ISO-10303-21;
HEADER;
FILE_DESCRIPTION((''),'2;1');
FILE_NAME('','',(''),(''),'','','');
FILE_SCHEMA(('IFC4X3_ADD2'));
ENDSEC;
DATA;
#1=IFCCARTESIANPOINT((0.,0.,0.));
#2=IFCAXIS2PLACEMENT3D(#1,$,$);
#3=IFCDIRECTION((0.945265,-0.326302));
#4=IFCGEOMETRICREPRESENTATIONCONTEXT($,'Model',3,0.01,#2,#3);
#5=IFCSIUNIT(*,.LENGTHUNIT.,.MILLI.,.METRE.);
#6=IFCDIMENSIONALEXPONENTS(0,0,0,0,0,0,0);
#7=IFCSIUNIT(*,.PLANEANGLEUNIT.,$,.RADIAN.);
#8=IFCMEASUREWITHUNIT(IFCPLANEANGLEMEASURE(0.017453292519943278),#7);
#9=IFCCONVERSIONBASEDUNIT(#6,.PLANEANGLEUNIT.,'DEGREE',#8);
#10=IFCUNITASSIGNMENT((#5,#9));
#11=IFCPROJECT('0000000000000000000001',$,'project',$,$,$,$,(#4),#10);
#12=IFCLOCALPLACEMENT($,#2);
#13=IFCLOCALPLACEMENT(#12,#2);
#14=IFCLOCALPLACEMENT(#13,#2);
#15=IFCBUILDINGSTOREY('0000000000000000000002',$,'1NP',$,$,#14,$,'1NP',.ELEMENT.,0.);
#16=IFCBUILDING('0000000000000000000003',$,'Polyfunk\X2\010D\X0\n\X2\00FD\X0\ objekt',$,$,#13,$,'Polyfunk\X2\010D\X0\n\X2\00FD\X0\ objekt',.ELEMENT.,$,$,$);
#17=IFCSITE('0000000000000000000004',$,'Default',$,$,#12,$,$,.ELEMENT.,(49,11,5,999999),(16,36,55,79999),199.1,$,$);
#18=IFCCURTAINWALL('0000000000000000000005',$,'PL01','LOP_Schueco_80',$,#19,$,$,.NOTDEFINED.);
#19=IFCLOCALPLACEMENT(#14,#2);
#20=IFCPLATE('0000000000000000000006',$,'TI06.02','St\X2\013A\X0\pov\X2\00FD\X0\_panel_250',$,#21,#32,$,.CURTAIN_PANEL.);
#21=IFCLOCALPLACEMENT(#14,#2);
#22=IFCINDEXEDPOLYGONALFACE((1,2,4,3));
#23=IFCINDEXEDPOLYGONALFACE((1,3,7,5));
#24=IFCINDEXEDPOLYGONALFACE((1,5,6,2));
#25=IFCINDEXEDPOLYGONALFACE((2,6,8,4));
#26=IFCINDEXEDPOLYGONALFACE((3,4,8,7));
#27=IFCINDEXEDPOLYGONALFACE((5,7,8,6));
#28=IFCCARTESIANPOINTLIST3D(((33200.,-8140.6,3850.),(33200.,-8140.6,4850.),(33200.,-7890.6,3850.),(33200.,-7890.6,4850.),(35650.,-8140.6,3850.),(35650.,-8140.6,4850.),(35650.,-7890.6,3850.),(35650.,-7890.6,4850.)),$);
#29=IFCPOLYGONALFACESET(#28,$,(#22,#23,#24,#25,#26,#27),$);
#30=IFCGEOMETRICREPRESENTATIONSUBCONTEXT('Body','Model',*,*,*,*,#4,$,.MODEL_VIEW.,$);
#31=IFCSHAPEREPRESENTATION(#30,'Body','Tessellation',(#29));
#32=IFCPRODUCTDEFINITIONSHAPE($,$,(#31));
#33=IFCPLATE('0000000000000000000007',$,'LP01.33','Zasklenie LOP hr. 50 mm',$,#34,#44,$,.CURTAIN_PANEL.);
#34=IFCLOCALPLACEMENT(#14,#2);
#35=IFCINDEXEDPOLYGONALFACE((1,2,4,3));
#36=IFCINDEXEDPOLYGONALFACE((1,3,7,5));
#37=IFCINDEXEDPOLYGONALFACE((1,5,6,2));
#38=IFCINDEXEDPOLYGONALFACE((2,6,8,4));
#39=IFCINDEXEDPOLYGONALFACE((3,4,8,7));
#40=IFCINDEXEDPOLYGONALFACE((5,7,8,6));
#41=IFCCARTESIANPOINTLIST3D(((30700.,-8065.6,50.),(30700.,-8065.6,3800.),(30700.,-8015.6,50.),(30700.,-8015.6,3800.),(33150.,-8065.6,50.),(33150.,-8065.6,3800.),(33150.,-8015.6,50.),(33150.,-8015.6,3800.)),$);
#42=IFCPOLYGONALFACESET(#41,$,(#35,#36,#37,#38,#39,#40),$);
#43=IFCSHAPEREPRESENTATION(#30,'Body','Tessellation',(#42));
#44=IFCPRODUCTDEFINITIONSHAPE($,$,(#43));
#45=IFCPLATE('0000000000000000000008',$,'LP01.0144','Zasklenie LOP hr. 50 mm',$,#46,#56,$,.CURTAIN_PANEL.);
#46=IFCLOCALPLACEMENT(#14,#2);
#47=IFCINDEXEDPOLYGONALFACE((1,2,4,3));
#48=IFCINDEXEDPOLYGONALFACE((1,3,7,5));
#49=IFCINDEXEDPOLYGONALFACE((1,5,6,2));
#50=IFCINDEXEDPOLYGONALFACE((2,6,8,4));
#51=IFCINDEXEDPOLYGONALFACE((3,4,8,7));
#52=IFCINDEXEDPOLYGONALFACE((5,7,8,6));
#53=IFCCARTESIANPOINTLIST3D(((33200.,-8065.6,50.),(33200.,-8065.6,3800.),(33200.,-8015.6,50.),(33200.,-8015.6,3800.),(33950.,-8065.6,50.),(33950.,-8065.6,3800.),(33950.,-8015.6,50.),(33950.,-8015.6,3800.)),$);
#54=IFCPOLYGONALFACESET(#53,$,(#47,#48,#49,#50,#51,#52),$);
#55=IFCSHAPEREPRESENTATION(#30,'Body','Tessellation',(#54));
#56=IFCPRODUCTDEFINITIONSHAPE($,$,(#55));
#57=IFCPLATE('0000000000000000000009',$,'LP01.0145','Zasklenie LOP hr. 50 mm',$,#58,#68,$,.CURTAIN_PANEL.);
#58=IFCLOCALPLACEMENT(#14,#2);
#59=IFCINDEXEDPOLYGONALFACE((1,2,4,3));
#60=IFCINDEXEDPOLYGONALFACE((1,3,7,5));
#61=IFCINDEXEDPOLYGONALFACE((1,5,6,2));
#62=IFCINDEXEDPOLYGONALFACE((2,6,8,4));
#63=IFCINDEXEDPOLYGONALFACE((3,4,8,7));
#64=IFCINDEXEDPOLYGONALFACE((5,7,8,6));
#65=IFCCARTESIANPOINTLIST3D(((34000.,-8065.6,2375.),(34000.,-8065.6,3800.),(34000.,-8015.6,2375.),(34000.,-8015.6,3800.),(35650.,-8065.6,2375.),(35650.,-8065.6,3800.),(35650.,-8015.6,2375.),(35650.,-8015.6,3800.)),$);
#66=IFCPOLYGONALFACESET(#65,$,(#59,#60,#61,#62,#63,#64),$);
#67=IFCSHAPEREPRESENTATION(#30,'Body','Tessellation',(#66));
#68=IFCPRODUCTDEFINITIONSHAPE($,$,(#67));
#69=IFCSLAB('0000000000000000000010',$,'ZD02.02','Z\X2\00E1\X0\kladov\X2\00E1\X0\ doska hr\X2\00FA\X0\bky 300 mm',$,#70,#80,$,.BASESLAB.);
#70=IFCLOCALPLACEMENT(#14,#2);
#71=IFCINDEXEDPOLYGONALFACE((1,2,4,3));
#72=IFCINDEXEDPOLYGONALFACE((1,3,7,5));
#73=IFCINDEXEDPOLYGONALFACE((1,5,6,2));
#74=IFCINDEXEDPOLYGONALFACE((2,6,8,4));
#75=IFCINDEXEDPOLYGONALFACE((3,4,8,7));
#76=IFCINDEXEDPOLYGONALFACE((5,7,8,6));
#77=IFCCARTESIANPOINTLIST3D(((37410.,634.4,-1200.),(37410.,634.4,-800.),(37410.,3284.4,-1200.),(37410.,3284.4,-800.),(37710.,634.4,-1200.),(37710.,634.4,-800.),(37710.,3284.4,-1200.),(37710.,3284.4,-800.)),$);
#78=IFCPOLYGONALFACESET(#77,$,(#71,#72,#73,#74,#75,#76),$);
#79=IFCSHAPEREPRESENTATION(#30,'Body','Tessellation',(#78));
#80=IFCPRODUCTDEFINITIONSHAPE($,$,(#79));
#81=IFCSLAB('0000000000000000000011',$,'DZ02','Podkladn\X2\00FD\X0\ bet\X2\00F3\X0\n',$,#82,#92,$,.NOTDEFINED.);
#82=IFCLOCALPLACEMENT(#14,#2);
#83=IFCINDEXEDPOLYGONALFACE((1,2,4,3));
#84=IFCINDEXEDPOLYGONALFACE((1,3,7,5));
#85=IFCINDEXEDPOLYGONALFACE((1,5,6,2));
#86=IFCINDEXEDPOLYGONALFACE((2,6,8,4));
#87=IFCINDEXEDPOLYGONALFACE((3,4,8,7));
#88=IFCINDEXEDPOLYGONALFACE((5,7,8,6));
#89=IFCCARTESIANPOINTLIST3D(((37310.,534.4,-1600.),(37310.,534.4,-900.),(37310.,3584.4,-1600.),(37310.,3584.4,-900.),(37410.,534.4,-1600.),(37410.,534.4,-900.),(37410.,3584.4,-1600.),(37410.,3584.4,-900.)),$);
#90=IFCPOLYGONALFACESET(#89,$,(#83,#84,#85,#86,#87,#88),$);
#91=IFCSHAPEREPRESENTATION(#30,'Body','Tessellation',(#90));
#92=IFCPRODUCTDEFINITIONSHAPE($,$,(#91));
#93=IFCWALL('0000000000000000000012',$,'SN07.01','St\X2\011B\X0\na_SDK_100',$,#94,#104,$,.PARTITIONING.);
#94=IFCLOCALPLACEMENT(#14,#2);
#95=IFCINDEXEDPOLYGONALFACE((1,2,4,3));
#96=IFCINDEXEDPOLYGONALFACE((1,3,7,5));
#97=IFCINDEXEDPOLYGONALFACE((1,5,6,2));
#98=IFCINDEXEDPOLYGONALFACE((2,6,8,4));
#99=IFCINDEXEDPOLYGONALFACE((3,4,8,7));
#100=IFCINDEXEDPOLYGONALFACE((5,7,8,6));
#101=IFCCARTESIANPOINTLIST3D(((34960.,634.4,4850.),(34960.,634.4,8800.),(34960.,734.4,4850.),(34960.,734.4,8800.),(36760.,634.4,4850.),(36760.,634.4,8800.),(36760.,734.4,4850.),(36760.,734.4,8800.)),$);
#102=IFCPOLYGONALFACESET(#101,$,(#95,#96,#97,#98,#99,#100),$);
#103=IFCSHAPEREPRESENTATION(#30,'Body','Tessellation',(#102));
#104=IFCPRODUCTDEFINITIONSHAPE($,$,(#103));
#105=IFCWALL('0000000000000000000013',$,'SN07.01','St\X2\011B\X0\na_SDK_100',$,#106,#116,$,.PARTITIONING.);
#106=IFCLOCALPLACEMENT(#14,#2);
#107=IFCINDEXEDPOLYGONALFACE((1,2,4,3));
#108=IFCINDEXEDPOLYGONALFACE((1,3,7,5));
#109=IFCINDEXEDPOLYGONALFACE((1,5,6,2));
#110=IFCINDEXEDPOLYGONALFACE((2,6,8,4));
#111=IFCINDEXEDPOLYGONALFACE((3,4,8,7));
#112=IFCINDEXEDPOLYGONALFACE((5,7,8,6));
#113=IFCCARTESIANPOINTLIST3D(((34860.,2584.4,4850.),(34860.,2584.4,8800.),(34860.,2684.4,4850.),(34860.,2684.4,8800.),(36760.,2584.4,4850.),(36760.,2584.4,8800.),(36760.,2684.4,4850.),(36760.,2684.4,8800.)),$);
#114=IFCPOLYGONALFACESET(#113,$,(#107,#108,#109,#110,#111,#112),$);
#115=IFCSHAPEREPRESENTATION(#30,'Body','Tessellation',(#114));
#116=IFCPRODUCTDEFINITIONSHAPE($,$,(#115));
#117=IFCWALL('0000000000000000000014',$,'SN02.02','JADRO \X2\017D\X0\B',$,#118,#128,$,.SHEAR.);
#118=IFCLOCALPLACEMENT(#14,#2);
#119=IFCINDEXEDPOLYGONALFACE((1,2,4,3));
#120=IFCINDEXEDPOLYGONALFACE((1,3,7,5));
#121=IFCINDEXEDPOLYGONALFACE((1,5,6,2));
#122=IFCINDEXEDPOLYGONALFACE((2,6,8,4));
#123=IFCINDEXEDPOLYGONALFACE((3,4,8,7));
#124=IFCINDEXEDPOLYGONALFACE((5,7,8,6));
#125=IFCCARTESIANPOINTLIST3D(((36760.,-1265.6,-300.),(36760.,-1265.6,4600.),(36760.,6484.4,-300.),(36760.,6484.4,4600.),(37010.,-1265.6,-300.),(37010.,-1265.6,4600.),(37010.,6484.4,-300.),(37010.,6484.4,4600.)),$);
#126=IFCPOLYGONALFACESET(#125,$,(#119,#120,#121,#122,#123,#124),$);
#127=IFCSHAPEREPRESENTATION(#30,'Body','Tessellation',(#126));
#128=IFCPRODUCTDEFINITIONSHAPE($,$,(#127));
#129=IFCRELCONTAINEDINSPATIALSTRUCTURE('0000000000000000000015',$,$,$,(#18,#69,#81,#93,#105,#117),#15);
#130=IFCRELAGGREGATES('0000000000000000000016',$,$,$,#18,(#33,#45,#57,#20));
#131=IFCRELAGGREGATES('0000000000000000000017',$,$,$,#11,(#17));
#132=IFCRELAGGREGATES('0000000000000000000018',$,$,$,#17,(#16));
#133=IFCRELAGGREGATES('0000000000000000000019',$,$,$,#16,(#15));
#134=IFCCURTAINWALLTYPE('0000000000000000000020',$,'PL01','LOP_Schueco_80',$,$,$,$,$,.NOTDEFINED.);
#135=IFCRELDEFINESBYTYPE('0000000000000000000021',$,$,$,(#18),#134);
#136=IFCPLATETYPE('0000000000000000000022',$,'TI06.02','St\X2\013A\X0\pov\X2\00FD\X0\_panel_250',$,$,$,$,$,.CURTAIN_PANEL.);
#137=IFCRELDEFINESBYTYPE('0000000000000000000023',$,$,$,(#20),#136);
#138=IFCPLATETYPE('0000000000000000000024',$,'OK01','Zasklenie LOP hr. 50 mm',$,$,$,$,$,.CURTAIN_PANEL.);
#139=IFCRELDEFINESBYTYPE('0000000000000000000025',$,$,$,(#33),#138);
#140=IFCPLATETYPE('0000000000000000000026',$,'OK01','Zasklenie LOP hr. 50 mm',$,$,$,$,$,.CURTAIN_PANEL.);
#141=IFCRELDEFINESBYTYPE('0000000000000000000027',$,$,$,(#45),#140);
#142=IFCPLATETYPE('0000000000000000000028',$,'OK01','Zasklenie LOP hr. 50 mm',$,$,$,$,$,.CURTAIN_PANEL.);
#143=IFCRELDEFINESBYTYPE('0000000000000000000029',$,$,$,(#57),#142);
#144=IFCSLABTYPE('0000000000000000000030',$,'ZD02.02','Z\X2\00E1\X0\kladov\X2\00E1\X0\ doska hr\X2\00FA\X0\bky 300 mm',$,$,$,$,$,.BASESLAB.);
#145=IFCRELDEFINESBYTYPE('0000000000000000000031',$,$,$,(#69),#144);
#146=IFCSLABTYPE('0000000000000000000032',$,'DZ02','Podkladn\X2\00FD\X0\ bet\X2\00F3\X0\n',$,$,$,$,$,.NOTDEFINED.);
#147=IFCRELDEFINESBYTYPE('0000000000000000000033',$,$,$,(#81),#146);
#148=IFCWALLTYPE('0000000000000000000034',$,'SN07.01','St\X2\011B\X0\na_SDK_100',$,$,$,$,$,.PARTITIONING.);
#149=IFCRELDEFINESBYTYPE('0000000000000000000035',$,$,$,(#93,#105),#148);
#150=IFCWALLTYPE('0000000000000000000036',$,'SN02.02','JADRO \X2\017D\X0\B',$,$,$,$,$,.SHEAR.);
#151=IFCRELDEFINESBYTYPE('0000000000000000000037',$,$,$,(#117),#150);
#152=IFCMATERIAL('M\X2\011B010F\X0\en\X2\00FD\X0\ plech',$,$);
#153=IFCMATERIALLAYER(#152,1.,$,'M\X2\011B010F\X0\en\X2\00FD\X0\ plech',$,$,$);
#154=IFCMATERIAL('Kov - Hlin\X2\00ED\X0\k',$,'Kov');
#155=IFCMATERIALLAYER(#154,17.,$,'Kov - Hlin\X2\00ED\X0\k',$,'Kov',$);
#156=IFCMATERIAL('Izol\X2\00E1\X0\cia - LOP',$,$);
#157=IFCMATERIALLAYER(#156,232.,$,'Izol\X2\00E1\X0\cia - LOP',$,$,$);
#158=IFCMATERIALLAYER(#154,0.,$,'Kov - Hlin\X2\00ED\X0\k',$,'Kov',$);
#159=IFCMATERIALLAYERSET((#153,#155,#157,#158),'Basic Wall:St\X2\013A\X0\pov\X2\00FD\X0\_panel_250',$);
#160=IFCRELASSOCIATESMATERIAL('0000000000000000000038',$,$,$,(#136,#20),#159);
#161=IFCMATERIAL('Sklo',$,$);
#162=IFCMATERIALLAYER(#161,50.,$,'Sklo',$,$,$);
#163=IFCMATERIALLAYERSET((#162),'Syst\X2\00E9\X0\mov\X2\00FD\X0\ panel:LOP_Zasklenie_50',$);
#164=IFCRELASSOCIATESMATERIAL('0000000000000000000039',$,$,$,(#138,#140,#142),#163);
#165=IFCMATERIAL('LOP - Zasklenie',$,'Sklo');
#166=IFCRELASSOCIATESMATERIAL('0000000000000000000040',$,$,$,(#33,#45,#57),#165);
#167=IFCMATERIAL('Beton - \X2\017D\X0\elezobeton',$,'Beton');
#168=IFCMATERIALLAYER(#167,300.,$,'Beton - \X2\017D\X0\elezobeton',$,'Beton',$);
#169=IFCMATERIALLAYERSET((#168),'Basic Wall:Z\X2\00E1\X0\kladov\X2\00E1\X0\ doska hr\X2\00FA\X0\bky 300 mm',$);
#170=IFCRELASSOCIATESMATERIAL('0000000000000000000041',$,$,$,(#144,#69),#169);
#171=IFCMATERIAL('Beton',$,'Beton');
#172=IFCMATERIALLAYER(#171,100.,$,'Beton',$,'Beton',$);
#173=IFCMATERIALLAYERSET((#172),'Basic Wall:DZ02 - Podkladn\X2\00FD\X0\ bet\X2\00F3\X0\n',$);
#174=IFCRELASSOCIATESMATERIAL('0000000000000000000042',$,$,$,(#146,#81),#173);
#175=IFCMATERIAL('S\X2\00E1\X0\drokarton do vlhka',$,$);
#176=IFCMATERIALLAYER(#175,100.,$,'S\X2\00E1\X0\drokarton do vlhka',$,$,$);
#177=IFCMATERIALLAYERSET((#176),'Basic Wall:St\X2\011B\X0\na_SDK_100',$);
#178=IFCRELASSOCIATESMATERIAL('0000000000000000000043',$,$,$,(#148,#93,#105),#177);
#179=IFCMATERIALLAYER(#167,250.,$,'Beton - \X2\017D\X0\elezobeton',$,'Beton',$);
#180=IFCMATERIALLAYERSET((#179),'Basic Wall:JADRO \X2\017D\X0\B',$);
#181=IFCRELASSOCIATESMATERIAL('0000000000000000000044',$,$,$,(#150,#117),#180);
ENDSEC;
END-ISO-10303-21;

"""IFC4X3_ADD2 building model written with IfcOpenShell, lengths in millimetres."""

from ifc_helpers import new_model, entity, si_unit, converted_unit, direction, frame, frame_2d, origin, place, context, subcontext, project, spatial, polyline, rectangle, extrude, clip, bounded_halfspace, source, transform, mapped, material, layer, layer_set, layer_usage, type_object, type_shapes, element, aggregate, save


model = new_model("IFC4X3_ADD2")

# Units and contexts
model_context = context("Model", 3, precision=0.01, world=origin(), true_north=direction((0.945265, -0.326302)))
body_context = subcontext(model_context, "Body", "Model", "MODEL_VIEW")
ifc_project = project(units=[si_unit("LENGTHUNIT", "METRE", prefix="MILLI"), converted_unit("PLANEANGLEUNIT", "DEGREE", entity("IfcPlaneAngleMeasure", 0.017453292519943278), si_unit("PLANEANGLEUNIT", "RADIAN"), dimensions=[0, 0, 0, 0, 0, 0, 0])], contexts=[model_context])

# Site, building, storey
site_placement = place(None, origin())
site = spatial("IfcSite", under=ifc_project, at=site_placement, Name="Default", CompositionType="ELEMENT", RefLatitude=(49, 11, 5, 999999), RefLongitude=(16, 36, 55, 79999), RefElevation=199.1)
building_placement = place(site_placement, origin())
building = spatial("IfcBuilding", under=site, at=building_placement, Name="Polyfunkčný objekt", LongName="Polyfunkčný objekt", CompositionType="ELEMENT")
storey_placement = place(building_placement, origin())
storey = spatial("IfcBuildingStorey", under=building, at=storey_placement, Name="1NP", LongName="1NP", CompositionType="ELEMENT", Elevation=0.0)

# Curtain wall, plates
curtain_wall_type = type_object("IfcCurtainWallType", Name="PL01", Description="LOP_Schueco_80", PredefinedType="NOTDEFINED")
curtain_wall_placement = place(storey_placement, origin())
curtain_wall = element("IfcCurtainWall", 1, at=curtain_wall_placement, inside=storey, type_object=curtain_wall_type, Name="PL01", Description="LOP_Schueco_80", PredefinedType="NOTDEFINED")
ifc_material_1 = material(Name="Měďený plech")
ifc_layer_1 = layer(ifc_material_1, 1.0, Name="Měďený plech")
ifc_material_2 = material(Name="Kov - Hliník", Category="Kov")
ifc_layer_2 = layer(ifc_material_2, 17.0, Name="Kov - Hliník", Category="Kov")
ifc_material_3 = material(Name="Izolácia - LOP")
ifc_layer_3 = layer(ifc_material_3, 232.0, Name="Izolácia - LOP")
ifc_layer_4 = layer(ifc_material_2, 0.0, Name="Kov - Hliník", Category="Kov")
ifc_layer_set_1 = layer_set([ifc_layer_1, ifc_layer_2, ifc_layer_3, ifc_layer_4], Name="Basic Wall:Stĺpový_panel_250")
ifc_layer_usage_1 = layer_usage(ifc_layer_set_1, "AXIS2", "POSITIVE", -125.0)
plate_type_1 = type_object("IfcPlateType", Name="TI06.02", Description="Stĺpový_panel_250", PredefinedType="CURTAIN_PANEL", material=ifc_layer_set_1)
plate_1_placement = place(storey_placement, frame((33200.0, -8015.6, 3850.0)))
plate_1 = element("IfcPlate", 2, at=plate_1_placement, type_object=plate_type_1, material=ifc_layer_usage_1, Name="TI06.02", Description="Stĺpový_panel_250", PredefinedType="CURTAIN_PANEL", context=body_context, shape_type="SweptSolid", body=[
    extrude(rectangle(XDim=250.0, YDim=2450.0, at=frame_2d((0.0, 0.0), x_axis=(1.0, 0.0))), frame((1225.0, 0.0, 0.0), z_axis=(0.0, 0.0, 1.0), x_axis=(0.0, 1.0, 0.0)), (0.0, 0.0, 1.0), 1000.0),
])
ifc_material_4 = material(Name="LOP - Zasklenie", Category="Sklo")
ifc_material_5 = material(Name="Sklo")
ifc_layer_5 = layer(ifc_material_5, 50.0, Name="Sklo")
ifc_layer_set_2 = layer_set([ifc_layer_5], Name="Systémový panel:LOP_Zasklenie_50")
plate_type_2 = type_object("IfcPlateType", Name="OK01", Description="Zasklenie LOP hr. 50 mm", PredefinedType="CURTAIN_PANEL", material=ifc_layer_set_2)
shared_shape_1 = source(origin(), body_context, "Body", "SweptSolid", [
    extrude(rectangle(XDim=3750.0, YDim=2450.0, at=frame_2d((-331.2, 0.0), x_axis=(1.0, 0.0))), frame((0.0, -50.0, 2206.2), z_axis=(0.0, 1.0, 0.0), x_axis=(0.0, 0.0, 1.0)), (0.0, 0.0, 1.0), 50.0),
])
type_shapes(plate_type_2, [shared_shape_1])
plate_2_placement = place(curtain_wall_placement, frame((31925.0, -8015.6, 50.0)))
plate_2 = element("IfcPlate", 3, at=plate_2_placement, type_object=plate_type_2, material=ifc_material_4, Name="LP01.33", Description="Zasklenie LOP hr. 50 mm", PredefinedType="CURTAIN_PANEL", context=body_context, shape_type="MappedRepresentation", body=[
    mapped(shared_shape_1, transform((0.0, 0.0, 0.0), scale=1.0)),
])
plate_type_3 = type_object("IfcPlateType", Name="OK01", Description="Zasklenie LOP hr. 50 mm", PredefinedType="CURTAIN_PANEL", material=ifc_layer_set_2)
shared_shape_2 = source(origin(), body_context, "Body", "SweptSolid", [
    extrude(rectangle(XDim=3750.0, YDim=750.0, at=frame_2d((-331.2, 0.0), x_axis=(1.0, 0.0))), frame((0.0, -50.0, 2206.2), z_axis=(0.0, 1.0, 0.0), x_axis=(0.0, 0.0, 1.0)), (0.0, 0.0, 1.0), 50.0),
])
type_shapes(plate_type_3, [shared_shape_2])
plate_3_placement = place(curtain_wall_placement, frame((33575.0, -8015.6, 50.0)))
plate_3 = element("IfcPlate", 4, at=plate_3_placement, type_object=plate_type_3, material=ifc_material_4, Name="LP01.0144", Description="Zasklenie LOP hr. 50 mm", PredefinedType="CURTAIN_PANEL", context=body_context, shape_type="MappedRepresentation", body=[
    mapped(shared_shape_2, transform((0.0, 0.0, 0.0), scale=1.0)),
])
plate_type_4 = type_object("IfcPlateType", Name="OK01", Description="Zasklenie LOP hr. 50 mm", PredefinedType="CURTAIN_PANEL", material=ifc_layer_set_2)
shared_shape_3 = source(origin(), body_context, "Body", "SweptSolid", [
    extrude(rectangle(XDim=1425.0, YDim=1650.0, at=frame_2d((87.6, 0.0), x_axis=(1.0, 0.0))), frame((0.0, -50.0, 624.9), z_axis=(0.0, 1.0, 0.0), x_axis=(0.0, 0.0, 1.0)), (0.0, 0.0, 1.0), 50.0),
])
type_shapes(plate_type_4, [shared_shape_3])
plate_4_placement = place(curtain_wall_placement, frame((34825.0, -8015.6, 2375.0)))
plate_4 = element("IfcPlate", 5, at=plate_4_placement, type_object=plate_type_4, material=ifc_material_4, Name="LP01.0145", Description="Zasklenie LOP hr. 50 mm", PredefinedType="CURTAIN_PANEL", context=body_context, shape_type="MappedRepresentation", body=[
    mapped(shared_shape_3, transform((0.0, 0.0, 0.0), scale=1.0)),
])
aggregate(curtain_wall, [plate_2, plate_3, plate_4, plate_1])

# Slabs
ifc_material_6 = material(Name="Beton - Železobeton", Category="Beton")
ifc_layer_6 = layer(ifc_material_6, 300.0, Name="Beton - Železobeton", Category="Beton")
ifc_layer_set_3 = layer_set([ifc_layer_6], Name="Basic Wall:Základová doska hrúbky 300 mm")
slab_type_1 = type_object("IfcSlabType", Name="ZD02.02", Description="Základová doska hrúbky 300 mm", PredefinedType="BASESLAB", material=ifc_layer_set_3)
slab_1_placement = place(storey_placement, frame((37560.0, 634.4, -1200.0), z_axis=(0.0, 0.0, 1.0), x_axis=(0.0, 1.0, 0.0)))
element("IfcSlab", 6, at=slab_1_placement, inside=storey, type_object=slab_type_1, material=ifc_layer_set_3, Name="ZD02.02", Description="Základová doska hrúbky 300 mm", PredefinedType="BASESLAB", context=body_context, shape_type="SweptSolid", body=[
    extrude(rectangle(XDim=2650.0, YDim=300.0, at=frame_2d((1325.0, 0.0), x_axis=(-1.0, 0.0))), origin(), (0.0, 0.0, 1.0), 400.0),
])
ifc_material_7 = material(Name="Beton", Category="Beton")
ifc_layer_7 = layer(ifc_material_7, 100.0, Name="Beton", Category="Beton")
ifc_layer_set_4 = layer_set([ifc_layer_7], Name="Basic Wall:DZ02 - Podkladný betón")
slab_type_2 = type_object("IfcSlabType", Name="DZ02", Description="Podkladný betón", PredefinedType="NOTDEFINED", material=ifc_layer_set_4)
slab_2_placement = place(storey_placement, frame((37360.0, 534.4, -1600.0), z_axis=(0.0, 0.0, 1.0), x_axis=(0.0, 1.0, 0.0)))
element("IfcSlab", 7, at=slab_2_placement, inside=storey, type_object=slab_type_2, material=ifc_layer_set_4, Name="DZ02", Description="Podkladný betón", PredefinedType="NOTDEFINED", context=body_context, shape_type="SweptSolid", body=[
    extrude(rectangle(XDim=3050.0, YDim=100.0, at=frame_2d((1525.0, 0.0), x_axis=(-1.0, 0.0))), origin(), (0.0, 0.0, 1.0), 700.0),
])

# Walls
ifc_material_8 = material(Name="Sádrokarton do vlhka")
ifc_layer_8 = layer(ifc_material_8, 100.0, Name="Sádrokarton do vlhka")
ifc_layer_set_5 = layer_set([ifc_layer_8], Name="Basic Wall:Stěna_SDK_100")
wall_type_1 = type_object("IfcWallType", Name="SN07.01", Description="Stěna_SDK_100", PredefinedType="PARTITIONING", material=ifc_layer_set_5)
wall_1_placement = place(storey_placement, frame((34960.0, 684.4, 4850.0)))
element("IfcWall", 8, at=wall_1_placement, inside=storey, type_object=wall_type_1, material=ifc_layer_set_5, Name="SN07.01", Description="Stěna_SDK_100", PredefinedType="PARTITIONING", context=body_context, shape_type="Clipping", body=[
    clip(clip(extrude(rectangle(XDim=1800.0, YDim=100.0, at=frame_2d((900.0, 0.0), x_axis=(-1.0, 0.0))), origin(), (0.0, 0.0, 1.0), 3950.0), bounded_halfspace(frame((1800.0, -50.0, 0.0), z_axis=(0.0, 0.0, 1.0), x_axis=(-1.0, 0.0, 0.0)), True, frame((1800.0, -50.0, 0.0)), polyline([(0.0, 0.0), (0.0, 100.0), (-1800.0, 100.0), (-1800.0, 0.0), (0.0, 0.0)]))), bounded_halfspace(frame((0.0, -50.0, 3950.0), z_axis=(0.0, 0.0, -1.0), x_axis=(1.0, 0.0, 0.0)), True, frame((0.0, -50.0, 3950.0)), polyline([(0.0, 0.0), (1800.0, 0.0), (1800.0, 100.0), (0.0, 100.0), (0.0, 0.0)]))),
])
wall_2_placement = place(storey_placement, frame((34860.0, 2634.4, 4850.0)))
element("IfcWall", 9, at=wall_2_placement, inside=storey, type_object=wall_type_1, material=ifc_layer_set_5, Name="SN07.01", Description="Stěna_SDK_100", PredefinedType="PARTITIONING", context=body_context, shape_type="Clipping", body=[
    clip(clip(extrude(rectangle(XDim=1900.0, YDim=100.0, at=frame_2d((950.0, 0.0), x_axis=(-1.0, 0.0))), origin(), (0.0, 0.0, 1.0), 3950.0), bounded_halfspace(frame((1900.0, -50.0, 0.0), z_axis=(0.0, 0.0, 1.0), x_axis=(-1.0, 0.0, 0.0)), True, frame((1900.0, -50.0, 0.0)), polyline([(0.0, 0.0), (0.0, 100.0), (-150.0, 100.0), (-1900.0, 100.0), (-1900.0, 0.0), (-1800.0, 0.0), (0.0, 0.0)]))), bounded_halfspace(frame((0.0, -50.0, 3950.0), z_axis=(0.0, 0.0, -1.0), x_axis=(1.0, 0.0, 0.0)), True, frame((0.0, -50.0, 3950.0)), polyline([(0.0, 0.0), (100.0, 0.0), (1900.0, 0.0), (1900.0, 100.0), (1750.0, 100.0), (0.0, 100.0), (0.0, 0.0)]))),
])
ifc_layer_9 = layer(ifc_material_6, 250.0, Name="Beton - Železobeton", Category="Beton")
ifc_layer_set_6 = layer_set([ifc_layer_9], Name="Basic Wall:JADRO ŽB")
wall_type_2 = type_object("IfcWallType", Name="SN02.02", Description="JADRO ŽB", PredefinedType="SHEAR", material=ifc_layer_set_6)
wall_3_placement = place(storey_placement, frame((36885.0, -1265.6, -300.0), z_axis=(0.0, 0.0, 1.0), x_axis=(0.0, 1.0, 0.0)))
element("IfcWall", 10, at=wall_3_placement, inside=storey, type_object=wall_type_2, material=ifc_layer_set_6, Name="SN02.02", Description="JADRO ŽB", PredefinedType="SHEAR", context=body_context, shape_type="Clipping", body=[
    clip(clip(extrude(rectangle(XDim=7750.0, YDim=250.0, at=frame_2d((3875.0, 0.0), x_axis=(-1.0, 0.0))), origin(), (0.0, 0.0, 1.0), 4900.0), bounded_halfspace(frame((7750.0, 125.0, 4900.0), z_axis=(0.0, 0.0, -1.0), x_axis=(0.0, -1.0, 0.0)), True, frame((7750.0, 125.0, 4900.0)), polyline([(0.0, 0.0), (-7750.0, 0.0), (-7750.0, -250.0), (-7500.0, -250.0), (-5800.0, -250.0), (-5550.0, -250.0), (-3200.0, -250.0), (-2950.0, -250.0), (-250.0, -250.0), (0.0, -250.0), (0.0, 0.0)]))), bounded_halfspace(frame((7750.0, -125.0, 0.0)), True, frame((7750.0, -125.0, 0.0)), polyline([(0.0, 0.0), (0.0, 250.0), (-390.0, 250.0), (-7750.0, 250.0), (-7750.0, 0.0), (-7500.0, 0.0), (-5800.0, 0.0), (-5550.0, 0.0), (-3200.0, 0.0), (-2950.0, 0.0), (-250.0, 0.0), (0.0, 0.0)]))),
])

save(model, "model.ifc")
